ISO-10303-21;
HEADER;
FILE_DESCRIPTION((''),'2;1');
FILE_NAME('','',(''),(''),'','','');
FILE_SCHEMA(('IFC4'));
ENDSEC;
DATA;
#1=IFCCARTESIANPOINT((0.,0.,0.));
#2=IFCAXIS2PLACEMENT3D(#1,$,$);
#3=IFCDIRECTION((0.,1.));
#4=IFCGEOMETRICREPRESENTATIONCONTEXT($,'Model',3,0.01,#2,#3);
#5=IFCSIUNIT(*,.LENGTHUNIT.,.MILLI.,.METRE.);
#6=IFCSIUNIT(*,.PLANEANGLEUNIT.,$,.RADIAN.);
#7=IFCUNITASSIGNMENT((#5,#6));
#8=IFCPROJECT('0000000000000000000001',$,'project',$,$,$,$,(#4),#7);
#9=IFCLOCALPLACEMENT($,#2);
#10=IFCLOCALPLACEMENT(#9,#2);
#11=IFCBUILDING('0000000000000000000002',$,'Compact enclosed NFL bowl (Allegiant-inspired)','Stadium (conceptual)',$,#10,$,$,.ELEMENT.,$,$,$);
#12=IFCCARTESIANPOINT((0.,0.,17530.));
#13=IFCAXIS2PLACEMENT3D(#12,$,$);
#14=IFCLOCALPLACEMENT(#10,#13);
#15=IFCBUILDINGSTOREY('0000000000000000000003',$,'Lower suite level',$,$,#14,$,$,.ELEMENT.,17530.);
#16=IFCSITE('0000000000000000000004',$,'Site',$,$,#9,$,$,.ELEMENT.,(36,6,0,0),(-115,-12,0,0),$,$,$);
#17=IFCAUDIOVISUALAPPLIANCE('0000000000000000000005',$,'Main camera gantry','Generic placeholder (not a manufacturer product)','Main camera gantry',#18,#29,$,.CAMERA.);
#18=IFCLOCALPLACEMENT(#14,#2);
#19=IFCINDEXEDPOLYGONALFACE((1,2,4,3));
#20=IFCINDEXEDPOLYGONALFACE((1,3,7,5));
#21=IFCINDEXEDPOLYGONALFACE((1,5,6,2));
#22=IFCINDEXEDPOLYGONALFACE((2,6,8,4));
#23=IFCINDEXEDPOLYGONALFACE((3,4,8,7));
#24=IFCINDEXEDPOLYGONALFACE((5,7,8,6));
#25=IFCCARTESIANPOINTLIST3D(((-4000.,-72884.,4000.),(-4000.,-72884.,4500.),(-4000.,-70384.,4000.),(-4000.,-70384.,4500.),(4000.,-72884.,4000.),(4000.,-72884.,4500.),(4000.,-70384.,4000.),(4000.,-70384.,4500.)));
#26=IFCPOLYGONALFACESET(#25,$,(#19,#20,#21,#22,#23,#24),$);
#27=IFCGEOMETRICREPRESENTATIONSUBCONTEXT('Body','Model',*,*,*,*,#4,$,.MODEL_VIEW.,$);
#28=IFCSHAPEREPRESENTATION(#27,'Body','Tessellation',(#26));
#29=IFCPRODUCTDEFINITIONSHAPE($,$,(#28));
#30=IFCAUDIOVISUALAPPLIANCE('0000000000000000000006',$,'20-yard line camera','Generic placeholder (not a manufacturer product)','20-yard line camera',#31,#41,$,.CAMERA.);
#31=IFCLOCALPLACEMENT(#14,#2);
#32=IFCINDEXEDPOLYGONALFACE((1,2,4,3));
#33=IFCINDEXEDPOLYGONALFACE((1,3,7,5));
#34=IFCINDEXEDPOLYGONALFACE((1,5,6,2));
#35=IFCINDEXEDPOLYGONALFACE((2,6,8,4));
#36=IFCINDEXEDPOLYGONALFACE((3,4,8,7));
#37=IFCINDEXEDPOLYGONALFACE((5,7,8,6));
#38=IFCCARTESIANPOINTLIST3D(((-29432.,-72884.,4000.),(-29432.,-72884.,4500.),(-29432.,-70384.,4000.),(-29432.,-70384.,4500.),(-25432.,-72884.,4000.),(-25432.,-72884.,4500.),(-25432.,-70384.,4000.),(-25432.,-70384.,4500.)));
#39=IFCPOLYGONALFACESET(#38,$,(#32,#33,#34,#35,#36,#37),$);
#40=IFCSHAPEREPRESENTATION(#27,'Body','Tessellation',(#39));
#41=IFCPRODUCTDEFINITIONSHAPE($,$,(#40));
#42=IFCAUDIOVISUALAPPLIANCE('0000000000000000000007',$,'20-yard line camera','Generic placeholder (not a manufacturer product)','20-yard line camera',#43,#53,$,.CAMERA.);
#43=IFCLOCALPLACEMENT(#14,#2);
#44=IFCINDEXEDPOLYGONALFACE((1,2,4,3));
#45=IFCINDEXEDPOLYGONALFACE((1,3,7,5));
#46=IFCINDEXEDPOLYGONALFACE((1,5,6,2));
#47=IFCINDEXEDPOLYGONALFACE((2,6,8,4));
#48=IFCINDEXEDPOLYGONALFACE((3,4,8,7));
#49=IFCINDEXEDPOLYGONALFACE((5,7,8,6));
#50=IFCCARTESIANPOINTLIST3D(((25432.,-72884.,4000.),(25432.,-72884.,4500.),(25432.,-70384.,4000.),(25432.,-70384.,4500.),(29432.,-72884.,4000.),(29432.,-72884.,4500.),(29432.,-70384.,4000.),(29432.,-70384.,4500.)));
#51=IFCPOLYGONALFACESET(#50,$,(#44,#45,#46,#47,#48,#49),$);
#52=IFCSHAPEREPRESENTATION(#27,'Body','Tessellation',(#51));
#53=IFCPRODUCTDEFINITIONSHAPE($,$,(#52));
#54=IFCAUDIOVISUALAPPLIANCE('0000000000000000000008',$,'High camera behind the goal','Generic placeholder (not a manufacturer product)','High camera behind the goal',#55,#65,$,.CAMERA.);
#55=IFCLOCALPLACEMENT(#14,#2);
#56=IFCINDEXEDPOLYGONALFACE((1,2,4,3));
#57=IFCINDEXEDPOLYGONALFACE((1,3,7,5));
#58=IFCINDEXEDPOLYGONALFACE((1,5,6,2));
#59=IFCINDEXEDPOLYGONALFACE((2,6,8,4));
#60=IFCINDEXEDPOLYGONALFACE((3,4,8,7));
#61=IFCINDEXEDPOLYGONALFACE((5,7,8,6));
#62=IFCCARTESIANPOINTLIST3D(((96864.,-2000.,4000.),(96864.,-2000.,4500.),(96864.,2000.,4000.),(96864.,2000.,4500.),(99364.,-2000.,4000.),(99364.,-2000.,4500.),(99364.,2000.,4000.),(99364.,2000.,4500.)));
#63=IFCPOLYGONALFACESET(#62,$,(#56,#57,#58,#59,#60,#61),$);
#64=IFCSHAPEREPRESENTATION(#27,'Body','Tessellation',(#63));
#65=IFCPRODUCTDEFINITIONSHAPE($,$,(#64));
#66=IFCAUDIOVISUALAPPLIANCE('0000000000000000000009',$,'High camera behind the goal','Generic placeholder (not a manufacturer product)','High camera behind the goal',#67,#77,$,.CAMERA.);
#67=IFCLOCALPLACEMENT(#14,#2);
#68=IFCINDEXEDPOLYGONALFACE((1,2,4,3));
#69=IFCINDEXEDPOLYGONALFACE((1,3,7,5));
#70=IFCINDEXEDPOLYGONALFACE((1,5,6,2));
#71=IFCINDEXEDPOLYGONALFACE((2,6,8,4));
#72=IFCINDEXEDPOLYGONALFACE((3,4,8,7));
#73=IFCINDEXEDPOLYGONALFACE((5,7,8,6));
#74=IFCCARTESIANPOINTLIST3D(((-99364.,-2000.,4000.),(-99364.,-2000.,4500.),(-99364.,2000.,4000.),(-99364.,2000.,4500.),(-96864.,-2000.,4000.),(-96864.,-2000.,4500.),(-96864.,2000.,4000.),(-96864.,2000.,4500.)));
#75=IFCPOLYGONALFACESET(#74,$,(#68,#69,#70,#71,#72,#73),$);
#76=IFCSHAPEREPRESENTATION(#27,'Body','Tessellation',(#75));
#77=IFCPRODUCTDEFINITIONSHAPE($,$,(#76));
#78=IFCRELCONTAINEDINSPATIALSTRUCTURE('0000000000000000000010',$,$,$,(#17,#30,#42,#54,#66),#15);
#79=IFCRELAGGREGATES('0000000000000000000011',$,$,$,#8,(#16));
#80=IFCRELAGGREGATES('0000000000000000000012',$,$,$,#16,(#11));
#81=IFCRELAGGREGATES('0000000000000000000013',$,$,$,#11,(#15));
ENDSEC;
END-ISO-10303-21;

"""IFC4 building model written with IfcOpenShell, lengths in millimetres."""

from ifc_helpers import new_model, si_unit, direction, frame, origin, place, context, subcontext, project, spatial, line, indexed_curve, outline, extrude, element, save


model = new_model("IFC4")

# Units and contexts
model_context = context("Model", 3, precision=0.01, world=origin(), true_north=direction((0.0, 1.0)))
body_context = subcontext(model_context, "Body", "Model", "MODEL_VIEW")
ifc_project = project(units=[si_unit("LENGTHUNIT", "METRE", prefix="MILLI"), si_unit("PLANEANGLEUNIT", "RADIAN")], contexts=[model_context])

# Site, building, storey
site_placement = place(None, origin())
site = spatial("IfcSite", under=ifc_project, at=site_placement, Name="Site", CompositionType="ELEMENT", RefLatitude=(36, 6, 0, 0), RefLongitude=(-115, -12, 0, 0))
building_placement = place(site_placement, origin())
building = spatial("IfcBuilding", under=site, at=building_placement, Name="Compact enclosed NFL bowl (Allegiant-inspired)", Description="Stadium (conceptual)", CompositionType="ELEMENT")
storey_placement = place(building_placement, frame((0.0, 0.0, 17530.0)))
storey = spatial("IfcBuildingStorey", under=building, at=storey_placement, Name="Lower suite level", CompositionType="ELEMENT", Elevation=17530.0)

# Shared definitions
placement = place(storey_placement, frame((0.0, 0.0, -17530.0)))

# Audio visual appliances
element("IfcAudioVisualAppliance", 1, at=placement, inside=storey, Name="Main camera gantry", Description="Generic placeholder (not a manufacturer product)", ObjectType="Main camera gantry", PredefinedType="CAMERA", context=body_context, shape_type="SweptSolid", body=[
    extrude(outline(indexed_curve([(-4000.0, -70384.0), (4000.0, -70384.0), (4000.0, -72884.0), (-4000.0, -72884.0)], segments=[line(1, 2), line(2, 3), line(3, 4), line(4, 1)], self_intersect=False)), frame((0.0, 0.0, 21530.0)), (0.0, 0.0, 1.0), 500.0),
])
element("IfcAudioVisualAppliance", 2, at=placement, inside=storey, Name="20-yard line camera", Description="Generic placeholder (not a manufacturer product)", ObjectType="20-yard line camera", PredefinedType="CAMERA", context=body_context, shape_type="SweptSolid", body=[
    extrude(outline(indexed_curve([(-29432.0, -70384.0), (-25432.0, -70384.0), (-25432.0, -72884.0), (-29432.0, -72884.0)], segments=[line(1, 2), line(2, 3), line(3, 4), line(4, 1)], self_intersect=False)), frame((0.0, 0.0, 21530.0)), (0.0, 0.0, 1.0), 500.0),
])
element("IfcAudioVisualAppliance", 3, at=placement, inside=storey, Name="20-yard line camera", Description="Generic placeholder (not a manufacturer product)", ObjectType="20-yard line camera", PredefinedType="CAMERA", context=body_context, shape_type="SweptSolid", body=[
    extrude(outline(indexed_curve([(25432.0, -70384.0), (29432.0, -70384.0), (29432.0, -72884.0), (25432.0, -72884.0)], segments=[line(1, 2), line(2, 3), line(3, 4), line(4, 1)], self_intersect=False)), frame((0.0, 0.0, 21530.0)), (0.0, 0.0, 1.0), 500.0),
])
element("IfcAudioVisualAppliance", 4, at=placement, inside=storey, Name="High camera behind the goal", Description="Generic placeholder (not a manufacturer product)", ObjectType="High camera behind the goal", PredefinedType="CAMERA", context=body_context, shape_type="SweptSolid", body=[
    extrude(outline(indexed_curve([(96864.0, -2000.0), (96864.0, 2000.0), (99364.0, 2000.0), (99364.0, -2000.0)], segments=[line(1, 2), line(2, 3), line(3, 4), line(4, 1)], self_intersect=False)), frame((0.0, 0.0, 21530.0)), (0.0, 0.0, 1.0), 500.0),
])
element("IfcAudioVisualAppliance", 5, at=placement, inside=storey, Name="High camera behind the goal", Description="Generic placeholder (not a manufacturer product)", ObjectType="High camera behind the goal", PredefinedType="CAMERA", context=body_context, shape_type="SweptSolid", body=[
    extrude(outline(indexed_curve([(-96864.0, 2000.0), (-96864.0, -2000.0), (-99364.0, -2000.0), (-99364.0, 2000.0)], segments=[line(1, 2), line(2, 3), line(3, 4), line(4, 1)], self_intersect=False)), frame((0.0, 0.0, 21530.0)), (0.0, 0.0, 1.0), 500.0),
])

save(model, "model.ifc")
